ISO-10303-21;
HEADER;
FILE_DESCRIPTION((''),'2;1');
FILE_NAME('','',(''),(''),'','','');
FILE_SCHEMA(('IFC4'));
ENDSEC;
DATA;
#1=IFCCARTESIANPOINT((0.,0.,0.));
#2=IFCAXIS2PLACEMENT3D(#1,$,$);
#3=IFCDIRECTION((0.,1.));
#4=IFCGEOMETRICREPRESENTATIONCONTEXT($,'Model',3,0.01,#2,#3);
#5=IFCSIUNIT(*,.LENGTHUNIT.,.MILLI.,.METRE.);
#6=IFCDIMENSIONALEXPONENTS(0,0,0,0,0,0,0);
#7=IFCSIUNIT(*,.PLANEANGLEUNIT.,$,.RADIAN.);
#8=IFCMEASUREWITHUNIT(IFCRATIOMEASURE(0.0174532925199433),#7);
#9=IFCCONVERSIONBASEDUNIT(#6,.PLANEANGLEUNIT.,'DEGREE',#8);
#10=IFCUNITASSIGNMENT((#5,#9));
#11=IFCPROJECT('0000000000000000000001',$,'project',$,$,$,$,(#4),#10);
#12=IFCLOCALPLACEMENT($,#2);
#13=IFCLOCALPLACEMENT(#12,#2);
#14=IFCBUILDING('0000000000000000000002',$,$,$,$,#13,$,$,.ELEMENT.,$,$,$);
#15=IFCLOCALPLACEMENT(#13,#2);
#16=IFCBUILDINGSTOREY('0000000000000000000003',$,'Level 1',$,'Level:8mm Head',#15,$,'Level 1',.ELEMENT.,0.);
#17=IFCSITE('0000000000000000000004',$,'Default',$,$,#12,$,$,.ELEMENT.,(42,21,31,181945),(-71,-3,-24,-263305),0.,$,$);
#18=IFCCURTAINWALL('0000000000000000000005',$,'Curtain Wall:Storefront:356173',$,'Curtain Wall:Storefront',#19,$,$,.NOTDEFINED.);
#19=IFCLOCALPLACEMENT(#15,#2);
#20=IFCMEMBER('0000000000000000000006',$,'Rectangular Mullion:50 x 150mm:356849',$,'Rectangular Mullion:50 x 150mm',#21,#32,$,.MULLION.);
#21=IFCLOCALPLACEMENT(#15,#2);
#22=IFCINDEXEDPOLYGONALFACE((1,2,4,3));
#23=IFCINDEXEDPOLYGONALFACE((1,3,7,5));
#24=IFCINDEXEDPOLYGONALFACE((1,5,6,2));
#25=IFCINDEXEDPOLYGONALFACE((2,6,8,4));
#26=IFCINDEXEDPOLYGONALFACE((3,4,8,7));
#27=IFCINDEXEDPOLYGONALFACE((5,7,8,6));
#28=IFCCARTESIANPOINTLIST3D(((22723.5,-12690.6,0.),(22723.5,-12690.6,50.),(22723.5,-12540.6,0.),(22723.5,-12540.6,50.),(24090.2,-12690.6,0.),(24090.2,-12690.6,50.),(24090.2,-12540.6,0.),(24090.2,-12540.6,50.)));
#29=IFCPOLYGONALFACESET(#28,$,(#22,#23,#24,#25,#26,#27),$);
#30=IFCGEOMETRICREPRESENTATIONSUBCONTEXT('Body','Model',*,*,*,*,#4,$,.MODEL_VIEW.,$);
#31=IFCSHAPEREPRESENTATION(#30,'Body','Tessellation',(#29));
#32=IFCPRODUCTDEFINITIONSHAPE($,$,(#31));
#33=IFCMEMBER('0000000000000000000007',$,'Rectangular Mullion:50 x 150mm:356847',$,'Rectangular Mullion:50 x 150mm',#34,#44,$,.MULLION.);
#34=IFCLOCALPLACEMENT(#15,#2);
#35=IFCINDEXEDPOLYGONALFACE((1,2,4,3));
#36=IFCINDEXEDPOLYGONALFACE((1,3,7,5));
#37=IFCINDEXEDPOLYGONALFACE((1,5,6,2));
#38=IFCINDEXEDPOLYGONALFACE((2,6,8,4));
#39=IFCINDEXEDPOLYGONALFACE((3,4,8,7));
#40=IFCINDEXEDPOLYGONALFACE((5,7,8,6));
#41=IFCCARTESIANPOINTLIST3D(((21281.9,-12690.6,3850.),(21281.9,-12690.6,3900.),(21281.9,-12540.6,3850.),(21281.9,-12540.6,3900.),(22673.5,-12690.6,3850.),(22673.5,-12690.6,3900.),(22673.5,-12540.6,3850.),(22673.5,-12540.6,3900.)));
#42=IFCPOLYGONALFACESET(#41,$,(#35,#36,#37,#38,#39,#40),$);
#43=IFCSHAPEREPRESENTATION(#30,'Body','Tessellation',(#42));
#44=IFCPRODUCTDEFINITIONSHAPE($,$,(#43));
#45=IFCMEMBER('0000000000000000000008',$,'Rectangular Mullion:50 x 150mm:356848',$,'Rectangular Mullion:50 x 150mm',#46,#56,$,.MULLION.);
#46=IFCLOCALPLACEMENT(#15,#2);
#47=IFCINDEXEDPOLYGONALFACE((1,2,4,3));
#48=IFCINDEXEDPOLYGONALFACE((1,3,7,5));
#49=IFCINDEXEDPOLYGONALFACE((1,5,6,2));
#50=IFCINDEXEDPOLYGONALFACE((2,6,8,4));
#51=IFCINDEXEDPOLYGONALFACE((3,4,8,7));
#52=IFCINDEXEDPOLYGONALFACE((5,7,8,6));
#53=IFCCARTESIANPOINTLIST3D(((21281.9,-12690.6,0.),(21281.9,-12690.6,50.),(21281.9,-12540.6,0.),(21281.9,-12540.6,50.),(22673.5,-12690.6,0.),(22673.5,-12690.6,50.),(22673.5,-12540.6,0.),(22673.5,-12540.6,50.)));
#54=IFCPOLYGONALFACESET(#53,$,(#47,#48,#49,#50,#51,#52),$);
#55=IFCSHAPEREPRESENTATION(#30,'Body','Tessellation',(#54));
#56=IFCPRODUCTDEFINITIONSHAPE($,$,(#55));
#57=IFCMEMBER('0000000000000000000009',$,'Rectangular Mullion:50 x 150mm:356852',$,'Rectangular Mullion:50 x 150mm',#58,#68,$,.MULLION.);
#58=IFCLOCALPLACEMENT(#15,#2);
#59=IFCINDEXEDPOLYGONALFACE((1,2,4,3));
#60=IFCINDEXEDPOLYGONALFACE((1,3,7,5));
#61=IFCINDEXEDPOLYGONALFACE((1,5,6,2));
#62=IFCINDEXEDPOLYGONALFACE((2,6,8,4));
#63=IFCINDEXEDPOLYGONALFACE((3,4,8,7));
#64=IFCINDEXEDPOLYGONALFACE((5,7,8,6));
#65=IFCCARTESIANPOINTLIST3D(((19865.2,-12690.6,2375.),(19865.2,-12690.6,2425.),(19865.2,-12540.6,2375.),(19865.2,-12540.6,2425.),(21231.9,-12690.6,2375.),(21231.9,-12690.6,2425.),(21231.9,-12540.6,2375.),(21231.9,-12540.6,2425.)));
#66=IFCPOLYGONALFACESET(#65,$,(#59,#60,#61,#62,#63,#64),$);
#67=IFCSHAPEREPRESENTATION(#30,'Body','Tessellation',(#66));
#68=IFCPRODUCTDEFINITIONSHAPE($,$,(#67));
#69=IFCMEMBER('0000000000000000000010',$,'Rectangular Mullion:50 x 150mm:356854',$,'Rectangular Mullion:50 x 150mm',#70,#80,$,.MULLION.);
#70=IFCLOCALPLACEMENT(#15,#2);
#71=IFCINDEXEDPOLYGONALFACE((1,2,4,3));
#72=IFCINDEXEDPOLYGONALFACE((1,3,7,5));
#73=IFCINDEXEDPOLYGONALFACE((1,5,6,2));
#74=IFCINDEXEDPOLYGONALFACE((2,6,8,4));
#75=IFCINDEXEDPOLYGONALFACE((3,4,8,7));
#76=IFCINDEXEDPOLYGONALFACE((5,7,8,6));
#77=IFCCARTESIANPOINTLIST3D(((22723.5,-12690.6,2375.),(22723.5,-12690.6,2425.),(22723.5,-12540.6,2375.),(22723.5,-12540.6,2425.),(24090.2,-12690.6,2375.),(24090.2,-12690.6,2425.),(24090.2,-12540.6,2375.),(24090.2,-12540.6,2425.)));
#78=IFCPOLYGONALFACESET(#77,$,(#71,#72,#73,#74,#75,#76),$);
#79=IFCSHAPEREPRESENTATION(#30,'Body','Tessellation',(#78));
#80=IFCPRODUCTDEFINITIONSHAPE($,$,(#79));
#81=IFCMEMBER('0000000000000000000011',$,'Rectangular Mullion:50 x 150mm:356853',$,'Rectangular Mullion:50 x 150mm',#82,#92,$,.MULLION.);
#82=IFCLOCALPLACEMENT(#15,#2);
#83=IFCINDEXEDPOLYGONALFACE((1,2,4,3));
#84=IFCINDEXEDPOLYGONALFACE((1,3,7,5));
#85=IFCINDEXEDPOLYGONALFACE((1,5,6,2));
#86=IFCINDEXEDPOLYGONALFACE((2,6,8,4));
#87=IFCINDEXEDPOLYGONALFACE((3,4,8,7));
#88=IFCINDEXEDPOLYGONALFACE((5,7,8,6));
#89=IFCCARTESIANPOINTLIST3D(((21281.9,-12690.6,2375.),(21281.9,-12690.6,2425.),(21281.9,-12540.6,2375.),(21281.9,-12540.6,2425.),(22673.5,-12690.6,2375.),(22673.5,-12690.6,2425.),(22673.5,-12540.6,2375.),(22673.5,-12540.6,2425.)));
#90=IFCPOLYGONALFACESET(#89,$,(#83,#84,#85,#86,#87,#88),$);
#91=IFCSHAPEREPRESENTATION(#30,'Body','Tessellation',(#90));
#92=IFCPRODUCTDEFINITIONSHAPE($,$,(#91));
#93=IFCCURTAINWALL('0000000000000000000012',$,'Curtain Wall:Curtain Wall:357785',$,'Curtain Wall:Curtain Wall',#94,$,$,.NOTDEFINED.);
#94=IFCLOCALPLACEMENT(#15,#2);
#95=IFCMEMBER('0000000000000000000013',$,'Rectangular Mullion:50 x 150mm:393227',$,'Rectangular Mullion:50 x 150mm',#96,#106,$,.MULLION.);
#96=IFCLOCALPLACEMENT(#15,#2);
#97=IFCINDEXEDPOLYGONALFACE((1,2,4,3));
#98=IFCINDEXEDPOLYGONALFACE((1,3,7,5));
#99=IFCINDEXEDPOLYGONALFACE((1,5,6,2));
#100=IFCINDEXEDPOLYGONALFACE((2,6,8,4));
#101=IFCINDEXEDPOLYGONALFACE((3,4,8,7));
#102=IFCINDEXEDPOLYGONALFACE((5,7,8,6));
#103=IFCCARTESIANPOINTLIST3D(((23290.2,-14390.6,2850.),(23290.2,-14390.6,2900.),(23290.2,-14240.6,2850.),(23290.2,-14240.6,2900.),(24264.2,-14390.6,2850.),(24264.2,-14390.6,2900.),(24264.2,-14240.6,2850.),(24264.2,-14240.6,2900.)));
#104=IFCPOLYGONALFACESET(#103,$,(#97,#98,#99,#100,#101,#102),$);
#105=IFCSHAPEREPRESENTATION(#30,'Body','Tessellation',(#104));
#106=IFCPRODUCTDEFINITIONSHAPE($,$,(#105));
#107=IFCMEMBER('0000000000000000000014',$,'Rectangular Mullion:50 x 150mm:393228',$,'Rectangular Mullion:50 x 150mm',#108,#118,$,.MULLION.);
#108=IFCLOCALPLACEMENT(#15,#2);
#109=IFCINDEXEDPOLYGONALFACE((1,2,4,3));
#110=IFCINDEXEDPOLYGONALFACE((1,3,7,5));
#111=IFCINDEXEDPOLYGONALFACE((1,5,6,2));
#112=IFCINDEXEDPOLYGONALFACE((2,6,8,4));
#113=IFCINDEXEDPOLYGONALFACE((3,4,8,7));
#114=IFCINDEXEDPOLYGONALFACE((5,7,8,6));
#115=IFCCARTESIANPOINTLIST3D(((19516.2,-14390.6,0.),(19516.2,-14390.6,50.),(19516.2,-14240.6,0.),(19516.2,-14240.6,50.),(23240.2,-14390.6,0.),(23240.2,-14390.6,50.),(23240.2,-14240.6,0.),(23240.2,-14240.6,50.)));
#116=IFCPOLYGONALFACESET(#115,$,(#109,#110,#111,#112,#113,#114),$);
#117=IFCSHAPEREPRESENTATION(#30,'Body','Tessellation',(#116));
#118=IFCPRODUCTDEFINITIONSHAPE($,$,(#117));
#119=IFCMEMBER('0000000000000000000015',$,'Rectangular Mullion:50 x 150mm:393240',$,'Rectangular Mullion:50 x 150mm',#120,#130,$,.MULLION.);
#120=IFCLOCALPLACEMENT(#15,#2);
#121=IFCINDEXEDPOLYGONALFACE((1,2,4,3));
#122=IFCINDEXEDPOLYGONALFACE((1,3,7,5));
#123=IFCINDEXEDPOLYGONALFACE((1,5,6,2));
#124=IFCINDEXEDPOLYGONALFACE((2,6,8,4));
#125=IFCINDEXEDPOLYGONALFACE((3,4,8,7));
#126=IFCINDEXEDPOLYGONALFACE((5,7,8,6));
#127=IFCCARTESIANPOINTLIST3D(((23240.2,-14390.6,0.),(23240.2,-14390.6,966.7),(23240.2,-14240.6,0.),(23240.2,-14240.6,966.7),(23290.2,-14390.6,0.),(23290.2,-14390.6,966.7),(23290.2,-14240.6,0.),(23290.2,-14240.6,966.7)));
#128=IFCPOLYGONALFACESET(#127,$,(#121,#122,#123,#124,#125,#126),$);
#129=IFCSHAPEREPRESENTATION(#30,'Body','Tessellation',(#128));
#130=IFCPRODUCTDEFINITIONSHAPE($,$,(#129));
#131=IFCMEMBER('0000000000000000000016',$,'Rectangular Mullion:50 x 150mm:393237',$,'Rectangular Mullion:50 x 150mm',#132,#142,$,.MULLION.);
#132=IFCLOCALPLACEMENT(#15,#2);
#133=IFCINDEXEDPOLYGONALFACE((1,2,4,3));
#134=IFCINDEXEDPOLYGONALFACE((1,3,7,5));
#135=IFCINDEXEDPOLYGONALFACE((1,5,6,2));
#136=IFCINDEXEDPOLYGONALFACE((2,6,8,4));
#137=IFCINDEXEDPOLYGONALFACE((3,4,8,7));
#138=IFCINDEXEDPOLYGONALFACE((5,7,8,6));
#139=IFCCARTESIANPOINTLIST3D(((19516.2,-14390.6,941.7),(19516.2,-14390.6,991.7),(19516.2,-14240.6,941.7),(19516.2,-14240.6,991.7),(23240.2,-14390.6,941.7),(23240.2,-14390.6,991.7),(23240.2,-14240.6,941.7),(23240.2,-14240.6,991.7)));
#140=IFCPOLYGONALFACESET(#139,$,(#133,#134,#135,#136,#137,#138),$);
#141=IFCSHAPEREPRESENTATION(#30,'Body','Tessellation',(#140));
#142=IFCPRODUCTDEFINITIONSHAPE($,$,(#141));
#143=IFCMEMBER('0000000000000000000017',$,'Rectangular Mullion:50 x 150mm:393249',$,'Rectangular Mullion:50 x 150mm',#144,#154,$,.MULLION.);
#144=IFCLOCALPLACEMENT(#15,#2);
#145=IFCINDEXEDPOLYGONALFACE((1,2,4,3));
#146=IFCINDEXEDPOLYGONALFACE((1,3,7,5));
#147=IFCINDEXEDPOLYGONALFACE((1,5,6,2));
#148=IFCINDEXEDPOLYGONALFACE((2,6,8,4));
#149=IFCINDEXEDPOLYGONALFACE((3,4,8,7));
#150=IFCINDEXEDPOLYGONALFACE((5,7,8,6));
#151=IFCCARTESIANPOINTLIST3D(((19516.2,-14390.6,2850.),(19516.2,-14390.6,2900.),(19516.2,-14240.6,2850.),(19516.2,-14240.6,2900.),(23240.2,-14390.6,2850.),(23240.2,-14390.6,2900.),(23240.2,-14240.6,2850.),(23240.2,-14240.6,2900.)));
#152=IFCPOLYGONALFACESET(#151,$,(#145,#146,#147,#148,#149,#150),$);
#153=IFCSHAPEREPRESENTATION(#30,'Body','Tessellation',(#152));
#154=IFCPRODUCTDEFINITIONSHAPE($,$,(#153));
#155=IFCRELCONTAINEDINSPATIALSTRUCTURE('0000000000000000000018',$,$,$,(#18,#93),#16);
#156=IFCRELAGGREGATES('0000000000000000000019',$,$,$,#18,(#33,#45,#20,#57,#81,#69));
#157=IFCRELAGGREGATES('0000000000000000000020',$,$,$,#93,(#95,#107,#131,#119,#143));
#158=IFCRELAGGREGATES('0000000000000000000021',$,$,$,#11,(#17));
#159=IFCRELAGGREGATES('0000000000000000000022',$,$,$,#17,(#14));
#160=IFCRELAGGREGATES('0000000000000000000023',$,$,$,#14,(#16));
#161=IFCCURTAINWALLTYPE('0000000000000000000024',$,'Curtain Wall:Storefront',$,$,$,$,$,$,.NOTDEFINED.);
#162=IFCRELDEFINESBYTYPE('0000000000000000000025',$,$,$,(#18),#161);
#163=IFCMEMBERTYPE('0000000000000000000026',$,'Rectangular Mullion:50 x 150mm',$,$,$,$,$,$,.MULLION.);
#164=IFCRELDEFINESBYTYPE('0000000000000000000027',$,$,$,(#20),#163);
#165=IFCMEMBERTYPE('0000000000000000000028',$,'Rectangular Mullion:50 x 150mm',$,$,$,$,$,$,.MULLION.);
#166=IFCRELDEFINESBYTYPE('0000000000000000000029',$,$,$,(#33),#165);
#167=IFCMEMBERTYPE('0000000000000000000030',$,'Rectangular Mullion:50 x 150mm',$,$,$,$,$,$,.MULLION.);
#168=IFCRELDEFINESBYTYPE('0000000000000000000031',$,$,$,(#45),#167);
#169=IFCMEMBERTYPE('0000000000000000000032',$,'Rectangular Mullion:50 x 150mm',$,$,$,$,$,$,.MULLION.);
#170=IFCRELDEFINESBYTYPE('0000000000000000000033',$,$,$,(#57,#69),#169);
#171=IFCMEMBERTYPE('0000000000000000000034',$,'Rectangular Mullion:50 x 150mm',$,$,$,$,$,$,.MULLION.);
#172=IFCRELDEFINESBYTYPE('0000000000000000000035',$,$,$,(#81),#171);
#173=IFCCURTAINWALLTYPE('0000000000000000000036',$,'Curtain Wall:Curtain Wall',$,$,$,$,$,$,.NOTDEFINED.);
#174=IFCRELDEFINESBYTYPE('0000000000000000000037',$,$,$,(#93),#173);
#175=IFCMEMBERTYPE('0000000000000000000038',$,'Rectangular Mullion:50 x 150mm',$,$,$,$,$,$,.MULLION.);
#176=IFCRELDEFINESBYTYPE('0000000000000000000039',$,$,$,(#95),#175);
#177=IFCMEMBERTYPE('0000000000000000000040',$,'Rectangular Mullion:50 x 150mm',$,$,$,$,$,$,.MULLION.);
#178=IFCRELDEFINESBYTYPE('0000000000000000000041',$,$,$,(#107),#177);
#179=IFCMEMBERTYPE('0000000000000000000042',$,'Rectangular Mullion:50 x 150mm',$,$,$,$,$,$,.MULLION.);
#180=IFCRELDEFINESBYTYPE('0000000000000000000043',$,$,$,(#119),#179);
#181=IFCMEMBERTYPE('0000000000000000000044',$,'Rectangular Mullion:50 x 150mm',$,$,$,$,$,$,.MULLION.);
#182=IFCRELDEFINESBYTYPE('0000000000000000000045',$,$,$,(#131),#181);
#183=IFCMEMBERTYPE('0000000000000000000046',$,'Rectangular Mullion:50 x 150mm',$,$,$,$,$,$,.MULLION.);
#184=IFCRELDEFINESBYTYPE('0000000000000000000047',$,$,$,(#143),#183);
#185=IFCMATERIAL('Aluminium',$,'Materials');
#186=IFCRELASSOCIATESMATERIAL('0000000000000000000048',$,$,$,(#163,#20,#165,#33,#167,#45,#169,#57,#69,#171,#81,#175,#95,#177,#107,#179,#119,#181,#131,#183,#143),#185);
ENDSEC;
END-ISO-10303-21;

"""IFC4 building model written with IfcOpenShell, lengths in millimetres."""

from ifc_helpers import new_model, entity, si_unit, converted_unit, direction, frame, origin, place, context, subcontext, project, spatial, indexed_curve, outline, extrude, source, transform, mapped, material, type_object, type_shapes, element, aggregate, save


model = new_model("IFC4")

# Units and contexts
model_context = context("Model", 3, precision=0.01, world=origin(), true_north=direction((0.0, 1.0)))
body_context = subcontext(model_context, "Body", "Model", "MODEL_VIEW")
ifc_project = project(units=[si_unit("LENGTHUNIT", "METRE", prefix="MILLI"), converted_unit("PLANEANGLEUNIT", "DEGREE", entity("IfcRatioMeasure", 0.0174532925199433), si_unit("PLANEANGLEUNIT", "RADIAN"), dimensions=[0, 0, 0, 0, 0, 0, 0])], contexts=[model_context])

# Site, building, storey
site_placement = place(None, origin())
site = spatial("IfcSite", under=ifc_project, at=site_placement, Name="Default", CompositionType="ELEMENT", RefLatitude=(42, 21, 31, 181945), RefLongitude=(-71, -3, -24, -263305), RefElevation=0.0)
building_placement = place(site_placement, origin())
building = spatial("IfcBuilding", under=site, at=building_placement, CompositionType="ELEMENT")
storey_placement = place(building_placement, origin())
storey = spatial("IfcBuildingStorey", under=building, at=storey_placement, Name="Level 1", ObjectType="Level:8mm Head", LongName="Level 1", CompositionType="ELEMENT", Elevation=0.0)

# Curtain walls, members
curtain_wall_type_1 = type_object("IfcCurtainWallType", Name="Curtain Wall:Storefront", PredefinedType="NOTDEFINED")
curtain_wall_1_placement = place(storey_placement, origin())
curtain_wall_1 = element("IfcCurtainWall", 1, at=curtain_wall_1_placement, inside=storey, type_object=curtain_wall_type_1, Name="Curtain Wall:Storefront:356173", ObjectType="Curtain Wall:Storefront", PredefinedType="NOTDEFINED")
ifc_material_1 = material(Name="Aluminium", Category="Materials")
member_type_1 = type_object("IfcMemberType", Name="Rectangular Mullion:50 x 150mm", PredefinedType="MULLION", material=ifc_material_1)
shared_shape_1 = source(origin(), body_context, "Body", "SweptSolid", [
    extrude(outline(indexed_curve([(-75.0, -25.0), (75.0, -25.0), (75.0, 25.0), (-75.0, 25.0), (-75.0, -25.0)], self_intersect=False)), frame((-25.0, 0.0, -1366.7), z_axis=(0.0, 0.0, 1.0), x_axis=(0.0, -1.0, 0.0)), (0.0, 0.0, 1.0), 1366.7),
])
type_shapes(member_type_1, [shared_shape_1])
member_1_placement = place(storey_placement, frame((22723.5, -12615.6, 0.0), z_axis=(-1.0, 0.0, 0.0), x_axis=(0.0, 0.0, -1.0)))
member_1 = element("IfcMember", 2, at=member_1_placement, type_object=member_type_1, material=ifc_material_1, Name="Rectangular Mullion:50 x 150mm:356849", ObjectType="Rectangular Mullion:50 x 150mm", PredefinedType="MULLION", context=body_context, shape_type="MappedRepresentation", body=[
    mapped(shared_shape_1, transform((0.0, 0.0, 0.0), scale=1.0)),
])
member_type_2 = type_object("IfcMemberType", Name="Rectangular Mullion:50 x 150mm", PredefinedType="MULLION", material=ifc_material_1)
shared_shape_2 = source(origin(), body_context, "Body", "SweptSolid", [
    extrude(outline(indexed_curve([(-75.0, -25.0), (75.0, -25.0), (75.0, 25.0), (-75.0, 25.0), (-75.0, -25.0)], self_intersect=False)), frame((-25.0, 0.0, -1391.7), z_axis=(0.0, 0.0, 1.0), x_axis=(0.0, -1.0, 0.0)), (0.0, 0.0, 1.0), 1391.7),
])
type_shapes(member_type_2, [shared_shape_2])
member_2_placement = place(storey_placement, frame((22673.5, -12615.6, 3900.0), z_axis=(1.0, 0.0, 0.0), x_axis=(0.0, 0.0, 1.0)))
member_2 = element("IfcMember", 3, at=member_2_placement, type_object=member_type_2, material=ifc_material_1, Name="Rectangular Mullion:50 x 150mm:356847", ObjectType="Rectangular Mullion:50 x 150mm", PredefinedType="MULLION", context=body_context, shape_type="MappedRepresentation", body=[
    mapped(shared_shape_2, transform((0.0, 0.0, 0.0), scale=1.0)),
])
member_type_3 = type_object("IfcMemberType", Name="Rectangular Mullion:50 x 150mm", PredefinedType="MULLION", material=ifc_material_1)
shared_shape_3 = source(origin(), body_context, "Body", "SweptSolid", [
    extrude(outline(indexed_curve([(-75.0, -25.0), (75.0, -25.0), (75.0, 25.0), (-75.0, 25.0), (-75.0, -25.0)], self_intersect=False)), frame((-25.0, 0.0, -1391.7), z_axis=(0.0, 0.0, 1.0), x_axis=(0.0, -1.0, 0.0)), (0.0, 0.0, 1.0), 1391.7),
])
type_shapes(member_type_3, [shared_shape_3])
member_3_placement = place(storey_placement, frame((21281.9, -12615.6, 0.0), z_axis=(-1.0, 0.0, 0.0), x_axis=(0.0, 0.0, -1.0)))
member_3 = element("IfcMember", 4, at=member_3_placement, type_object=member_type_3, material=ifc_material_1, Name="Rectangular Mullion:50 x 150mm:356848", ObjectType="Rectangular Mullion:50 x 150mm", PredefinedType="MULLION", context=body_context, shape_type="MappedRepresentation", body=[
    mapped(shared_shape_3, transform((0.0, 0.0, 0.0), scale=1.0)),
])
member_type_4 = type_object("IfcMemberType", Name="Rectangular Mullion:50 x 150mm", PredefinedType="MULLION", material=ifc_material_1)
shared_shape_4 = source(origin(), body_context, "Body", "SweptSolid", [
    extrude(outline(indexed_curve([(-75.0, -25.0), (75.0, -25.0), (75.0, 25.0), (-75.0, 25.0), (-75.0, -25.0)], self_intersect=False)), frame((0.0, 0.0, -1366.7), z_axis=(0.0, 0.0, 1.0), x_axis=(0.0, -1.0, 0.0)), (0.0, 0.0, 1.0), 1366.7),
])
type_shapes(member_type_4, [shared_shape_4])
member_4_placement = place(storey_placement, frame((21231.9, -12615.6, 2400.0), z_axis=(1.0, 0.0, 0.0), x_axis=(0.0, 0.0, 1.0)))
member_4 = element("IfcMember", 5, at=member_4_placement, type_object=member_type_4, material=ifc_material_1, Name="Rectangular Mullion:50 x 150mm:356852", ObjectType="Rectangular Mullion:50 x 150mm", PredefinedType="MULLION", context=body_context, shape_type="MappedRepresentation", body=[
    mapped(shared_shape_4, transform((0.0, 0.0, 0.0), scale=1.0)),
])
member_5_placement = place(storey_placement, frame((24090.2, -12615.6, 2400.0), z_axis=(1.0, 0.0, 0.0), x_axis=(0.0, 0.0, 1.0)))
member_5 = element("IfcMember", 6, at=member_5_placement, type_object=member_type_4, material=ifc_material_1, Name="Rectangular Mullion:50 x 150mm:356854", ObjectType="Rectangular Mullion:50 x 150mm", PredefinedType="MULLION", context=body_context, shape_type="MappedRepresentation", body=[
    mapped(shared_shape_4, transform((0.0, 0.0, 0.0), scale=1.0)),
])
member_type_5 = type_object("IfcMemberType", Name="Rectangular Mullion:50 x 150mm", PredefinedType="MULLION", material=ifc_material_1)
shared_shape_5 = source(origin(), body_context, "Body", "SweptSolid", [
    extrude(outline(indexed_curve([(-75.0, -25.0), (75.0, -25.0), (75.0, 25.0), (-75.0, 25.0), (-75.0, -25.0)], self_intersect=False)), frame((0.0, 0.0, -1391.7), z_axis=(0.0, 0.0, 1.0), x_axis=(0.0, -1.0, 0.0)), (0.0, 0.0, 1.0), 1391.7),
])
type_shapes(member_type_5, [shared_shape_5])
member_6_placement = place(storey_placement, frame((22673.5, -12615.6, 2400.0), z_axis=(1.0, 0.0, 0.0), x_axis=(0.0, 0.0, 1.0)))
member_6 = element("IfcMember", 7, at=member_6_placement, type_object=member_type_5, material=ifc_material_1, Name="Rectangular Mullion:50 x 150mm:356853", ObjectType="Rectangular Mullion:50 x 150mm", PredefinedType="MULLION", context=body_context, shape_type="MappedRepresentation", body=[
    mapped(shared_shape_5, transform((0.0, 0.0, 0.0), scale=1.0)),
])
curtain_wall_type_2 = type_object("IfcCurtainWallType", Name="Curtain Wall:Curtain Wall", PredefinedType="NOTDEFINED")
curtain_wall_2_placement = place(storey_placement, origin())
curtain_wall_2 = element("IfcCurtainWall", 8, at=curtain_wall_2_placement, inside=storey, type_object=curtain_wall_type_2, Name="Curtain Wall:Curtain Wall:357785", ObjectType="Curtain Wall:Curtain Wall", PredefinedType="NOTDEFINED")
member_type_6 = type_object("IfcMemberType", Name="Rectangular Mullion:50 x 150mm", PredefinedType="MULLION", material=ifc_material_1)
shared_shape_6 = source(origin(), body_context, "Body", "SweptSolid", [
    extrude(outline(indexed_curve([(-75.0, -25.0), (75.0, -25.0), (75.0, 25.0), (-75.0, 25.0), (-75.0, -25.0)], self_intersect=False)), frame((-25.0, 0.0, -974.0), z_axis=(0.0, 0.0, 1.0), x_axis=(0.0, -1.0, 0.0)), (0.0, 0.0, 1.0), 974.0),
])
type_shapes(member_type_6, [shared_shape_6])
member_7_placement = place(storey_placement, frame((24264.2, -14315.6, 2900.0), z_axis=(1.0, 0.0, 0.0), x_axis=(0.0, 0.0, 1.0)))
member_7 = element("IfcMember", 9, at=member_7_placement, type_object=member_type_6, material=ifc_material_1, Name="Rectangular Mullion:50 x 150mm:393227", ObjectType="Rectangular Mullion:50 x 150mm", PredefinedType="MULLION", context=body_context, shape_type="MappedRepresentation", body=[
    mapped(shared_shape_6, transform((0.0, 0.0, 0.0), scale=1.0)),
])
member_type_7 = type_object("IfcMemberType", Name="Rectangular Mullion:50 x 150mm", PredefinedType="MULLION", material=ifc_material_1)
shared_shape_7 = source(origin(), body_context, "Body", "SweptSolid", [
    extrude(outline(indexed_curve([(-75.0, -25.0), (75.0, -25.0), (75.0, 25.0), (-75.0, 25.0), (-75.0, -25.0)], self_intersect=False)), frame((-25.0, 0.0, -3724.0), z_axis=(0.0, 0.0, 1.0), x_axis=(0.0, -1.0, 0.0)), (0.0, 0.0, 1.0), 3724.0),
])
type_shapes(member_type_7, [shared_shape_7])
member_8_placement = place(storey_placement, frame((19516.2, -14315.6, 0.0), z_axis=(-1.0, 0.0, 0.0), x_axis=(0.0, 0.0, -1.0)))
member_8 = element("IfcMember", 10, at=member_8_placement, type_object=member_type_7, material=ifc_material_1, Name="Rectangular Mullion:50 x 150mm:393228", ObjectType="Rectangular Mullion:50 x 150mm", PredefinedType="MULLION", context=body_context, shape_type="MappedRepresentation", body=[
    mapped(shared_shape_7, transform((0.0, 0.0, 0.0), scale=1.0)),
])
member_type_8 = type_object("IfcMemberType", Name="Rectangular Mullion:50 x 150mm", PredefinedType="MULLION", material=ifc_material_1)
shared_shape_8 = source(origin(), body_context, "Body", "SweptSolid", [
    extrude(outline(indexed_curve([(-75.0, -25.0), (75.0, -25.0), (75.0, 25.0), (-75.0, 25.0), (-75.0, -25.0)], self_intersect=False)), frame((0.0, 0.0, -966.7), z_axis=(0.0, 0.0, 1.0), x_axis=(0.0, -1.0, 0.0)), (0.0, 0.0, 1.0), 966.7),
])
type_shapes(member_type_8, [shared_shape_8])
member_9_placement = place(storey_placement, frame((23265.2, -14315.6, 0.0), z_axis=(0.0, 0.0, -1.0), x_axis=(1.0, 0.0, 0.0)))
member_9 = element("IfcMember", 11, at=member_9_placement, type_object=member_type_8, material=ifc_material_1, Name="Rectangular Mullion:50 x 150mm:393240", ObjectType="Rectangular Mullion:50 x 150mm", PredefinedType="MULLION", context=body_context, shape_type="MappedRepresentation", body=[
    mapped(shared_shape_8, transform((0.0, 0.0, 0.0), scale=1.0)),
])
member_type_9 = type_object("IfcMemberType", Name="Rectangular Mullion:50 x 150mm", PredefinedType="MULLION", material=ifc_material_1)
shared_shape_9 = source(origin(), body_context, "Body", "SweptSolid", [
    extrude(outline(indexed_curve([(-75.0, -25.0), (75.0, -25.0), (75.0, 25.0), (-75.0, 25.0), (-75.0, -25.0)], self_intersect=False)), frame((0.0, 0.0, -3724.0), z_axis=(0.0, 0.0, 1.0), x_axis=(0.0, -1.0, 0.0)), (0.0, 0.0, 1.0), 3724.0),
])
type_shapes(member_type_9, [shared_shape_9])
member_10_placement = place(storey_placement, frame((23240.2, -14315.6, 966.7), z_axis=(1.0, 0.0, 0.0), x_axis=(0.0, 0.0, 1.0)))
member_10 = element("IfcMember", 12, at=member_10_placement, type_object=member_type_9, material=ifc_material_1, Name="Rectangular Mullion:50 x 150mm:393237", ObjectType="Rectangular Mullion:50 x 150mm", PredefinedType="MULLION", context=body_context, shape_type="MappedRepresentation", body=[
    mapped(shared_shape_9, transform((0.0, 0.0, 0.0), scale=1.0)),
])
member_type_10 = type_object("IfcMemberType", Name="Rectangular Mullion:50 x 150mm", PredefinedType="MULLION", material=ifc_material_1)
shared_shape_10 = source(origin(), body_context, "Body", "SweptSolid", [
    extrude(outline(indexed_curve([(-75.0, -25.0), (75.0, -25.0), (75.0, 25.0), (-75.0, 25.0), (-75.0, -25.0)], self_intersect=False)), frame((-25.0, 0.0, -3724.0), z_axis=(0.0, 0.0, 1.0), x_axis=(0.0, -1.0, 0.0)), (0.0, 0.0, 1.0), 3724.0),
])
type_shapes(member_type_10, [shared_shape_10])
member_11_placement = place(storey_placement, frame((23240.2, -14315.6, 2900.0), z_axis=(1.0, 0.0, 0.0), x_axis=(0.0, 0.0, 1.0)))
member_11 = element("IfcMember", 13, at=member_11_placement, type_object=member_type_10, material=ifc_material_1, Name="Rectangular Mullion:50 x 150mm:393249", ObjectType="Rectangular Mullion:50 x 150mm", PredefinedType="MULLION", context=body_context, shape_type="MappedRepresentation", body=[
    mapped(shared_shape_10, transform((0.0, 0.0, 0.0), scale=1.0)),
])

aggregate(curtain_wall_1, [member_2, member_3, member_1, member_4, member_6, member_5])

aggregate(curtain_wall_2, [member_7, member_8, member_10, member_9, member_11])

save(model, "model.ifc")
